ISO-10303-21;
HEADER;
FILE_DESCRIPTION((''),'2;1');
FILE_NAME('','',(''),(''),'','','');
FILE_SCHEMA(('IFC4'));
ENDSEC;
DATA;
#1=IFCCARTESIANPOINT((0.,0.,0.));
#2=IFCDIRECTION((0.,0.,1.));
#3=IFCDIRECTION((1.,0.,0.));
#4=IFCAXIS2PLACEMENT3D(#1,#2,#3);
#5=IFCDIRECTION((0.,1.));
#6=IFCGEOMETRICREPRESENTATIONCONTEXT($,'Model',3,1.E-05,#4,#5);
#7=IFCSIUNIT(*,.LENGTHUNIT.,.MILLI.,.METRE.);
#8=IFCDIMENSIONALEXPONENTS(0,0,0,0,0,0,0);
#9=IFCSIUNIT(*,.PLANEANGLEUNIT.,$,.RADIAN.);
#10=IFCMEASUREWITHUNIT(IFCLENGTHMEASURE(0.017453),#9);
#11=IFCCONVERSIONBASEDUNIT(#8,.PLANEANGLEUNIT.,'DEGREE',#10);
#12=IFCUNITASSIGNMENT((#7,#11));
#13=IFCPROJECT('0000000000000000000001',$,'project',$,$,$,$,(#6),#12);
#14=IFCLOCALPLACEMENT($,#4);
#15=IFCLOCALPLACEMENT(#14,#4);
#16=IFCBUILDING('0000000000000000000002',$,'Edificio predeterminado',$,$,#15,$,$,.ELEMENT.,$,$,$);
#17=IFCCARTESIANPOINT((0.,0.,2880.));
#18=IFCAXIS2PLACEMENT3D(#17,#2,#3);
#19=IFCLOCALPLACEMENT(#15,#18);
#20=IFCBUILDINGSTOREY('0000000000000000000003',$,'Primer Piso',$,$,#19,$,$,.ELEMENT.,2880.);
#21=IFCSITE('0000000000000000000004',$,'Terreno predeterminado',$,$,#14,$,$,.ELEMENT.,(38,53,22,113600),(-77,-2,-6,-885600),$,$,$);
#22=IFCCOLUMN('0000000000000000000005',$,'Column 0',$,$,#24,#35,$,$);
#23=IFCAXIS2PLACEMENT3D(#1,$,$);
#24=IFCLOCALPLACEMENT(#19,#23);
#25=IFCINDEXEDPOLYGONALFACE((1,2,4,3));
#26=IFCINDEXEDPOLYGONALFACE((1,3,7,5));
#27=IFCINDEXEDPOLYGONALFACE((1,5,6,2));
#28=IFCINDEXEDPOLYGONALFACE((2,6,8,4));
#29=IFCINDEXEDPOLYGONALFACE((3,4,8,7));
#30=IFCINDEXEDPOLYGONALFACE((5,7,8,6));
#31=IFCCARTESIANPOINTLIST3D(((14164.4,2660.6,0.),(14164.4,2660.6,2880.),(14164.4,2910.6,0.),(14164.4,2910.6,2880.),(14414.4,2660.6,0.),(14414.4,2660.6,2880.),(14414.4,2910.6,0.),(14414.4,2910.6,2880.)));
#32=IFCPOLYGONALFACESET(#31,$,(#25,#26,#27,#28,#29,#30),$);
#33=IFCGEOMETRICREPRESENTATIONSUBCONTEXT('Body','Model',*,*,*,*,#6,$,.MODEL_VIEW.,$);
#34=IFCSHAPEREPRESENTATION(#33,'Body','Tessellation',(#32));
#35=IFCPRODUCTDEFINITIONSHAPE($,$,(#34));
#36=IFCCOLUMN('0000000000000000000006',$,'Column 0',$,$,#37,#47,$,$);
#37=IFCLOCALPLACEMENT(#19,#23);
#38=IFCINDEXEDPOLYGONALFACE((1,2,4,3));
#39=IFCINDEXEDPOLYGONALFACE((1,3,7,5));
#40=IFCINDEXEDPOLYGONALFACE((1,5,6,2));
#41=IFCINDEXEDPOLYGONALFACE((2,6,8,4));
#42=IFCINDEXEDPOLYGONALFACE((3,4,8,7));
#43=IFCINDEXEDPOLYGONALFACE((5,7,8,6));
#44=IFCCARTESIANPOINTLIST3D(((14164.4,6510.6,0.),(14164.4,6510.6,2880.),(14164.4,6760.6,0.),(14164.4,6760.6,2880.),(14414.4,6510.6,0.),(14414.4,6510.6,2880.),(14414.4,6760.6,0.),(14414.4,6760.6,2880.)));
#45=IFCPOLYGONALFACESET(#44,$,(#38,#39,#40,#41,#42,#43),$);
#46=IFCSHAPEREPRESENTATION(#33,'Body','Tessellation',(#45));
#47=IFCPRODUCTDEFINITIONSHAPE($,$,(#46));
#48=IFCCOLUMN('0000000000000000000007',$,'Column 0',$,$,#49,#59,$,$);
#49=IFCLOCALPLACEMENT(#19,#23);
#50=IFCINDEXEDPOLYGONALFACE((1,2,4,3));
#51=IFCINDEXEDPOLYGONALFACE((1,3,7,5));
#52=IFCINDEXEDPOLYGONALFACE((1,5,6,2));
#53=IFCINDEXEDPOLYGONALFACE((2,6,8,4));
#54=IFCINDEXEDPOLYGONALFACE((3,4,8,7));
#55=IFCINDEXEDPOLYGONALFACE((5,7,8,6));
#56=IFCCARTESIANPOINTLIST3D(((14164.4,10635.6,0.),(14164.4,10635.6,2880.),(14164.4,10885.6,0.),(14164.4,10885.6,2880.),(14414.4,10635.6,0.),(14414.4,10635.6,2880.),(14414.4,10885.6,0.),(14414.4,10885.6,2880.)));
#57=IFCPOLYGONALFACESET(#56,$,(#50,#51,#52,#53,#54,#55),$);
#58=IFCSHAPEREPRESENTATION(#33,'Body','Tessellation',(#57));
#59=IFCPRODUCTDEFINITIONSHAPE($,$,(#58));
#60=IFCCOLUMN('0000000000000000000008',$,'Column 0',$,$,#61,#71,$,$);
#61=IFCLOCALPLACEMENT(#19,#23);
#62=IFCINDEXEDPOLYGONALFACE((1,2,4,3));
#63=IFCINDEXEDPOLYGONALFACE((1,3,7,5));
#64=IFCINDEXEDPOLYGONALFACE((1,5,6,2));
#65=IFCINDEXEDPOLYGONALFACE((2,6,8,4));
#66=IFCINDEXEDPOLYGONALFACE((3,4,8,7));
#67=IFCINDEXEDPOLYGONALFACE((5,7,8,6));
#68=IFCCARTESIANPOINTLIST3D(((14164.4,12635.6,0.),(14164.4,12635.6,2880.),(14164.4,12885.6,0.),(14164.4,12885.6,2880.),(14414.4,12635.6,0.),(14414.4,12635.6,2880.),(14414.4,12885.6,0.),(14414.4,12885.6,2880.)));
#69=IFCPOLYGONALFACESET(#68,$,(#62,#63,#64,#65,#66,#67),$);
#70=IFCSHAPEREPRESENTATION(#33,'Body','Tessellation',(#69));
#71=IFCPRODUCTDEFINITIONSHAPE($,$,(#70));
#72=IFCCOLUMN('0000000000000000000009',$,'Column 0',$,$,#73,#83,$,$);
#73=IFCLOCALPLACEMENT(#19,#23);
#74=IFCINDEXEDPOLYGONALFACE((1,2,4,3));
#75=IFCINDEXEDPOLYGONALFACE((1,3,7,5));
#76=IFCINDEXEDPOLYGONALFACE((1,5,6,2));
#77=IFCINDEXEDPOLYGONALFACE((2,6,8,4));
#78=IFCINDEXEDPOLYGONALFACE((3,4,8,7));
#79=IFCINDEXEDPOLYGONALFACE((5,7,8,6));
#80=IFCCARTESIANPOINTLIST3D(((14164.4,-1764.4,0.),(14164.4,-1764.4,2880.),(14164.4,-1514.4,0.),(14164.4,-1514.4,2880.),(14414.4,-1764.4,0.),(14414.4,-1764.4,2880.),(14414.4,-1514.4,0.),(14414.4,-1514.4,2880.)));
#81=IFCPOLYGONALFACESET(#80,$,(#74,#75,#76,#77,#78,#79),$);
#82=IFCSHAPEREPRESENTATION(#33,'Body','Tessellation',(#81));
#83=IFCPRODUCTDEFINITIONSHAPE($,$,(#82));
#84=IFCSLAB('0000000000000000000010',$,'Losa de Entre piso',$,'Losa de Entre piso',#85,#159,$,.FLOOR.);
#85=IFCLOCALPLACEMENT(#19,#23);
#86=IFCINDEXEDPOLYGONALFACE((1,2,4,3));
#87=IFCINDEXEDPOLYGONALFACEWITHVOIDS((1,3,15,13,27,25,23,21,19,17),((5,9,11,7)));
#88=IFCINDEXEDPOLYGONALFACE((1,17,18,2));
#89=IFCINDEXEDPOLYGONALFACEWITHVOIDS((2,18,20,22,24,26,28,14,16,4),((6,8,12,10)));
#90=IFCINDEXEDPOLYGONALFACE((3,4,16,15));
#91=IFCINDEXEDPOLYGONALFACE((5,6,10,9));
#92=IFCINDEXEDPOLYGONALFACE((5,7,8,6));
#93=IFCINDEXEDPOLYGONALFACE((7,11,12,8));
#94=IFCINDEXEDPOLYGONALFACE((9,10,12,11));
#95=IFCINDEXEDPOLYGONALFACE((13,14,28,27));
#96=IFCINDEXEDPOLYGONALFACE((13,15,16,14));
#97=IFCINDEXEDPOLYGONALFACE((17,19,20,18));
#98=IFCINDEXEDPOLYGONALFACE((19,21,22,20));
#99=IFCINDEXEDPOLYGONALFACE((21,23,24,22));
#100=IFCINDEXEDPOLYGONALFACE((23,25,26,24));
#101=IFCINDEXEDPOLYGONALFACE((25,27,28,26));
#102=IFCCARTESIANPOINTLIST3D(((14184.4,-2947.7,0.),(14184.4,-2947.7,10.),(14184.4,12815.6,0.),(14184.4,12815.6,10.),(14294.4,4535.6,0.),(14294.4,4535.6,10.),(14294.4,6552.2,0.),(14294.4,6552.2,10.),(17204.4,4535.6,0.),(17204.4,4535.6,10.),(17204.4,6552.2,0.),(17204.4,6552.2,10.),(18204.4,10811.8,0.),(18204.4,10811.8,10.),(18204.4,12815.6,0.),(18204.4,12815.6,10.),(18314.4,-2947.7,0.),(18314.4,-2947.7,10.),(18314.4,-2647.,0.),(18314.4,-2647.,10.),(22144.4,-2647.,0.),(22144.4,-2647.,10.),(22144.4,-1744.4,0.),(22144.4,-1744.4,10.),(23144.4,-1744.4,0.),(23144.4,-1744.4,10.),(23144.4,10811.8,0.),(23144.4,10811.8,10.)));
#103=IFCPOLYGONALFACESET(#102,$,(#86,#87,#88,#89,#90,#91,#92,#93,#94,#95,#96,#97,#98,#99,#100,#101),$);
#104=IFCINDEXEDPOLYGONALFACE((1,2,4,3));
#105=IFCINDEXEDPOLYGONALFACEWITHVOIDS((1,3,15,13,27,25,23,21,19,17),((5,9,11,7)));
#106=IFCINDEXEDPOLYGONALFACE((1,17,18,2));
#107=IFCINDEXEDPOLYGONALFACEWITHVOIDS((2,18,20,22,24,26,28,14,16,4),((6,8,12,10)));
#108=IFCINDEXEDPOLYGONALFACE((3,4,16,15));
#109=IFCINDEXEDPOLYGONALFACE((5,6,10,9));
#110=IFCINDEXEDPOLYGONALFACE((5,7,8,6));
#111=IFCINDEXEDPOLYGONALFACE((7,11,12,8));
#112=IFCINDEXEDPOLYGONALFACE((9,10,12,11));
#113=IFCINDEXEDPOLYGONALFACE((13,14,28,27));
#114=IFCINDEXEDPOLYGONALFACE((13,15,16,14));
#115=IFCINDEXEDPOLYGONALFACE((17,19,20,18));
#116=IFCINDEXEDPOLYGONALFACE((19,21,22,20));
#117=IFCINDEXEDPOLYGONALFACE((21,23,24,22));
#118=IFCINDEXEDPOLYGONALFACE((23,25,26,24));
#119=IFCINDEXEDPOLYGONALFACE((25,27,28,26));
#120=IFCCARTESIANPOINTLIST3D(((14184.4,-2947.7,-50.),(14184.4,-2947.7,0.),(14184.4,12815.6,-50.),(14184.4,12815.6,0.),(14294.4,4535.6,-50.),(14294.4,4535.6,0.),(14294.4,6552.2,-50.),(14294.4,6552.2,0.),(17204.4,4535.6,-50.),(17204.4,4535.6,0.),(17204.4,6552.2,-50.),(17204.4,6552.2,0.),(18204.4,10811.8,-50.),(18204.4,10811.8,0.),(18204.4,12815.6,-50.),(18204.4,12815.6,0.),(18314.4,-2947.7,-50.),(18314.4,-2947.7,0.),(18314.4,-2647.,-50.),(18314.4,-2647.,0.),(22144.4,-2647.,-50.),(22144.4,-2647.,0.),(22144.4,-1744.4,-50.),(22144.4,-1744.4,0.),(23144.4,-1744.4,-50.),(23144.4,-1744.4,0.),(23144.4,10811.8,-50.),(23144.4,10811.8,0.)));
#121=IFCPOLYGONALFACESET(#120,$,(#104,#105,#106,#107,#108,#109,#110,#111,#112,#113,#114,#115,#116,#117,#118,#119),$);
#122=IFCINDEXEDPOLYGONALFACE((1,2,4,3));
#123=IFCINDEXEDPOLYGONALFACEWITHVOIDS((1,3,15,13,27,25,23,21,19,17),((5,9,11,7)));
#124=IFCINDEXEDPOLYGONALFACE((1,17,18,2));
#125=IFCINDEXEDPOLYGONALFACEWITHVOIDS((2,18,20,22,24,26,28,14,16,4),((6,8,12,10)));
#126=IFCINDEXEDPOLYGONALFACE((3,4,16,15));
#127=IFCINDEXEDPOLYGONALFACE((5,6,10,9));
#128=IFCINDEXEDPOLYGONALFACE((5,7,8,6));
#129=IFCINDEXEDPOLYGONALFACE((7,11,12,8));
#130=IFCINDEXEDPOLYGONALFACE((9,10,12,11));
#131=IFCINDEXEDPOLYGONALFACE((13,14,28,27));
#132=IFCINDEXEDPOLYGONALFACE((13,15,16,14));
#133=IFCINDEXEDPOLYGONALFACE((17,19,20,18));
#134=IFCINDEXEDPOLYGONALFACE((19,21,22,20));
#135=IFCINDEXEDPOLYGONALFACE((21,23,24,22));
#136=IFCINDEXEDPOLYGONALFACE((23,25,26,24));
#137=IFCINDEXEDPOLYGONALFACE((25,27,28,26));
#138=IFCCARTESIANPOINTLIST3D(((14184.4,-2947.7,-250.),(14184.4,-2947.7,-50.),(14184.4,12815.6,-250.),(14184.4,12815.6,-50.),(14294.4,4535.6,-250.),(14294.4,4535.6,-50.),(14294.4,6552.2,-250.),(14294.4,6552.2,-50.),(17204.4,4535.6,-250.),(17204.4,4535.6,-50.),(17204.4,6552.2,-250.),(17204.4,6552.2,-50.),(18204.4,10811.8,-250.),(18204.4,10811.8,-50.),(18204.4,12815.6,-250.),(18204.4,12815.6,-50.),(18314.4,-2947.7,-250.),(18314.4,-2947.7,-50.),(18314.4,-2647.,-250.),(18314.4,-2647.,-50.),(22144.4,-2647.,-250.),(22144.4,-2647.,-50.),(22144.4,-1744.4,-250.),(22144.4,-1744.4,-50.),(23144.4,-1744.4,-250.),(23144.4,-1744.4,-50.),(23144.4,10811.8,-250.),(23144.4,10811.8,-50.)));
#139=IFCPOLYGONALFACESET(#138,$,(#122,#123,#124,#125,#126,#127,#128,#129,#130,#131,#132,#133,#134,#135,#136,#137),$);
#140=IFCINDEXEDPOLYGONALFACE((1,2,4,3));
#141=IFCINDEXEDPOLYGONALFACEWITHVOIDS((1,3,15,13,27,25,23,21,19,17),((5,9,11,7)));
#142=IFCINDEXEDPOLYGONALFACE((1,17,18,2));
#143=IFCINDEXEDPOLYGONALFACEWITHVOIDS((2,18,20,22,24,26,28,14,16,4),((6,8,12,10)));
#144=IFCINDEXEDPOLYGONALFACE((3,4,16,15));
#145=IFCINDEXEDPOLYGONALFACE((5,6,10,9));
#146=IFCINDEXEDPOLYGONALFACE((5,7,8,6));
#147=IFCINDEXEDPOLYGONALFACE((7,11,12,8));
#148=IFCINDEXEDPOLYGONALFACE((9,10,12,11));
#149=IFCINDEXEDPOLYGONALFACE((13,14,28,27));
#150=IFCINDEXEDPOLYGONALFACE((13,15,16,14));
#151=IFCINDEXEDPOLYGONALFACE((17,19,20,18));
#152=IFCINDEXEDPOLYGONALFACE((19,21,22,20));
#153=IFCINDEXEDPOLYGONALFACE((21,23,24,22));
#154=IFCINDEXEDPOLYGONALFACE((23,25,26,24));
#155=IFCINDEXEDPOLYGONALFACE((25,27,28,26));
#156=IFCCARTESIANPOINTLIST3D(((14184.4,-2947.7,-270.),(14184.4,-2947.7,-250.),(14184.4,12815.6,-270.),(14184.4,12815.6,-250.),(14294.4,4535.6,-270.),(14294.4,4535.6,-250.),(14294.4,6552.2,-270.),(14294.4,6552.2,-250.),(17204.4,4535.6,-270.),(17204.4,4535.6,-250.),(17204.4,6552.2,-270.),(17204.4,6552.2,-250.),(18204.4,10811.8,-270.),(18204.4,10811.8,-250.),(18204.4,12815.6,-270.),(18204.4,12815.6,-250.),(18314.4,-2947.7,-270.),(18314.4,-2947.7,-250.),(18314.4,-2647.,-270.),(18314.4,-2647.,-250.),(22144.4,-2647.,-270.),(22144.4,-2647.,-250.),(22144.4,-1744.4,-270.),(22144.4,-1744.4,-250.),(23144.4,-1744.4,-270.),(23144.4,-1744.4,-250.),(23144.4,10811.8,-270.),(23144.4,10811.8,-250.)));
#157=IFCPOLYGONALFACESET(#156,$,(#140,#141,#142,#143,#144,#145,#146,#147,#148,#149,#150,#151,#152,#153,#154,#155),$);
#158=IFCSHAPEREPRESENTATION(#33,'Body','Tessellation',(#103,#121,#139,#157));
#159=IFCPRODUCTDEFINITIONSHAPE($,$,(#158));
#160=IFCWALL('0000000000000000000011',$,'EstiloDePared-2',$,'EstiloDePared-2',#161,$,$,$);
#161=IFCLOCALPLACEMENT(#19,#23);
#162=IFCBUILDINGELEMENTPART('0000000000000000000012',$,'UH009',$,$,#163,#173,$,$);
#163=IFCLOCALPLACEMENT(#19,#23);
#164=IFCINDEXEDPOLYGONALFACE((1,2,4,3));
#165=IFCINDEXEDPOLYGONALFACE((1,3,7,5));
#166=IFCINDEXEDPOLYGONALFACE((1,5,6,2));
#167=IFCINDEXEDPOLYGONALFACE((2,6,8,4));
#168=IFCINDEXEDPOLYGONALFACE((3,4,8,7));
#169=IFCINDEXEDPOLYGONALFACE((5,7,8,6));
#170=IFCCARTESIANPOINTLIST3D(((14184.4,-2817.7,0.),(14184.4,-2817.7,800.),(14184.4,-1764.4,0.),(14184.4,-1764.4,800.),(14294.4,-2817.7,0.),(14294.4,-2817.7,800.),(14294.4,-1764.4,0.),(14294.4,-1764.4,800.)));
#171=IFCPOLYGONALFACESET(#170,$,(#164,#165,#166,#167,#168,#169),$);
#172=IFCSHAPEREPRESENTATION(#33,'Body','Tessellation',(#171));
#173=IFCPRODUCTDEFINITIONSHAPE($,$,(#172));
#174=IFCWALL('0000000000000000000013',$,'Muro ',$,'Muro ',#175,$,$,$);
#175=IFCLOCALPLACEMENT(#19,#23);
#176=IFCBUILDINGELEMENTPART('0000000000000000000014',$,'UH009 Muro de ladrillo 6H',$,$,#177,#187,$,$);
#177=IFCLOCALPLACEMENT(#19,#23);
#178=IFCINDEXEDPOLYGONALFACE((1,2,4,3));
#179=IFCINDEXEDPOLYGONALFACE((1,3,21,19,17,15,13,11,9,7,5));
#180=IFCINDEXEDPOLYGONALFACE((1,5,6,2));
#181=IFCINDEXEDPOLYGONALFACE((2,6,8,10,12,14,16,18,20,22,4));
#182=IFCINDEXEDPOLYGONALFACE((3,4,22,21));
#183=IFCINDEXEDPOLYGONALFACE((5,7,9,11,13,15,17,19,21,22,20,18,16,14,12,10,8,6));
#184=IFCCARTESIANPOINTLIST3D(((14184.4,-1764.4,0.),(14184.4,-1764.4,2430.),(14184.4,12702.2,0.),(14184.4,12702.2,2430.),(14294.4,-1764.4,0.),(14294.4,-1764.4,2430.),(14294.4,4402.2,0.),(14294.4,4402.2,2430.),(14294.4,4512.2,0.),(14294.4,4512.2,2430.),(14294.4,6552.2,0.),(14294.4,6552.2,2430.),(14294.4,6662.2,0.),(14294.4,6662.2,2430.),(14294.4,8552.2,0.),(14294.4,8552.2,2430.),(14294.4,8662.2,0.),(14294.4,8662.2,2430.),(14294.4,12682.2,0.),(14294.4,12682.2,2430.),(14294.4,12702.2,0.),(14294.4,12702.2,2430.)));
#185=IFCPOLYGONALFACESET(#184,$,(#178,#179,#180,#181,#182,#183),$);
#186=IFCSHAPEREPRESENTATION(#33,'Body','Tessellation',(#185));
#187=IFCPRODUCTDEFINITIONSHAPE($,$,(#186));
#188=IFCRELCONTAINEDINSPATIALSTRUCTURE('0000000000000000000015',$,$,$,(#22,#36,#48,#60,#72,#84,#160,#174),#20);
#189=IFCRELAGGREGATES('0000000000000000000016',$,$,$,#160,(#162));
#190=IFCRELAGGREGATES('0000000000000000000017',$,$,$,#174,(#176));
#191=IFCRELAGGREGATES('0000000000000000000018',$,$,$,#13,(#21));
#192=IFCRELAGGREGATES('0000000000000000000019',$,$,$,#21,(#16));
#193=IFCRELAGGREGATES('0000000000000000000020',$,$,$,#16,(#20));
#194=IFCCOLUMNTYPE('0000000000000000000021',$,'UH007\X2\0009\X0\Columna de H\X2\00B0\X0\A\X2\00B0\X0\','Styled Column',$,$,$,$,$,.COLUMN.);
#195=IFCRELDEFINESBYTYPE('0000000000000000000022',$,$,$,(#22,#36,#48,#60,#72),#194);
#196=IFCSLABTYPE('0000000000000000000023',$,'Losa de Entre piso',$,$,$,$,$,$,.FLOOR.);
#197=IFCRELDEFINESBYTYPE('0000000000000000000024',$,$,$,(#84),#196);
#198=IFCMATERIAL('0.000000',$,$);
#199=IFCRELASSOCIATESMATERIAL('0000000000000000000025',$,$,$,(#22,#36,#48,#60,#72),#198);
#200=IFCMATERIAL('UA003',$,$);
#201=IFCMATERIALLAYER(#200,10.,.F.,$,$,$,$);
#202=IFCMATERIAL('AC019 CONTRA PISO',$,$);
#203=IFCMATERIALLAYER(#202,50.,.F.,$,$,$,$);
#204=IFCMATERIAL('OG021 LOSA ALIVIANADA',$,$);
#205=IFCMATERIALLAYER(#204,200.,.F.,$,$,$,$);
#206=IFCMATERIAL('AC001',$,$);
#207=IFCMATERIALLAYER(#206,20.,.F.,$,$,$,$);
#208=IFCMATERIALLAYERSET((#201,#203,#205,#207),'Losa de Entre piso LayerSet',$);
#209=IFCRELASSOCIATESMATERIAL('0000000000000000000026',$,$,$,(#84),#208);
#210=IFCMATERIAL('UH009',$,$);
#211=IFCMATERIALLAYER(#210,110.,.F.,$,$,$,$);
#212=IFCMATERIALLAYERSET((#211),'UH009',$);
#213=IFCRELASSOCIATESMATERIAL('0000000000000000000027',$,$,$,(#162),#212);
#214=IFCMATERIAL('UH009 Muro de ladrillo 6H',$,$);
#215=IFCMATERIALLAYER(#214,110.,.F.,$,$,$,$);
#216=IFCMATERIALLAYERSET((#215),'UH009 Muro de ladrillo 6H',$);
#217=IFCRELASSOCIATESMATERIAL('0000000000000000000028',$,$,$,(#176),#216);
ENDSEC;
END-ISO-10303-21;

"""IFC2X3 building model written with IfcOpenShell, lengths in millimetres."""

from ifc_helpers import new_model, entity, si_unit, converted_unit, direction, frame, origin_with_axes, place, context, subcontext, project, spatial, polyline, outline, extrude, material, layer, layer_set, layer_usage, type_object, element, aggregate, save


model = new_model("IFC2X3")

# Units and contexts
model_context = context("Model", 3, precision=1e-05, world=origin_with_axes(), true_north=direction((0.0, 1.0)))
body_context = subcontext(model_context, "Body", "Model", "MODEL_VIEW")
ifc_project = project(units=[si_unit("LENGTHUNIT", "METRE", prefix="MILLI"), converted_unit("PLANEANGLEUNIT", "DEGREE", entity("IfcLengthMeasure", 0.017453), si_unit("PLANEANGLEUNIT", "RADIAN"), dimensions=[0, 0, 0, 0, 0, 0, 0])], contexts=[model_context])

# Site, building, storey
site_placement = place(None, origin_with_axes())
site = spatial("IfcSite", under=ifc_project, at=site_placement, Name="Terreno predeterminado", CompositionType="ELEMENT", RefLatitude=(38, 53, 22, 113600), RefLongitude=(-77, -2, -6, -885600))
building_placement = place(site_placement, origin_with_axes())
building = spatial("IfcBuilding", under=site, at=building_placement, Name="Edificio predeterminado", CompositionType="ELEMENT")
storey_placement = place(building_placement, frame((0.0, 0.0, 2880.0), z_axis=(0.0, 0.0, 1.0), x_axis=(1.0, 0.0, 0.0)))
storey = spatial("IfcBuildingStorey", under=building, at=storey_placement, Name="Primer Piso", CompositionType="ELEMENT", Elevation=2880.0)

# Columns
ifc_material_1 = material(Name="0.000000")
column_type = type_object("IfcColumnType", Name="UH007\tColumna de H°A°", Description="Styled Column", PredefinedType="COLUMN")
for number, where, z_axis, x_axis, name in (
    (1, (14289.4, 2785.6, 0.0), (0.0, 0.0, 1.0), (1.0, 0.0, 0.0), "Column 0"),
    (2, (14289.4, 6635.6, 0.0), (0.0, 0.0, 1.0), (1.0, 0.0, 0.0), "Column 0"),
    (3, (14289.4, 10760.6, 0.0), (0.0, 0.0, 1.0), (1.0, 0.0, 0.0), "Column 0"),
    (4, (14289.4, 12760.6, 0.0), (0.0, 0.0, 1.0), (1.0, 0.0, 0.0), "Column 0"),
    (5, (14289.4, -1639.4, 0.0), (0.0, 0.0, 1.0), (1.0, 0.0, 0.0), "Column 0"),
):
    element("IfcColumn", number, at=place(storey_placement, frame(where, z_axis=z_axis, x_axis=x_axis)), inside=storey, type_object=column_type, material=ifc_material_1, Name=name, context=body_context, shape_type="SweptSolid", body=[
        extrude(outline(polyline([(-125.0, -125.0), (125.0, -125.0), (125.0, 125.0), (-125.0, 125.0), (-125.0, -125.0)])), origin_with_axes(), (0.0, 0.0, 1.0), 2880.0),
    ])

# Slab
ifc_material_2 = material(Name="UA003")
ifc_layer_1 = layer(ifc_material_2, 10.0, ventilated=False)
ifc_material_3 = material(Name="AC019 CONTRA PISO")
ifc_layer_2 = layer(ifc_material_3, 50.0, ventilated=False)
ifc_material_4 = material(Name="OG021 LOSA ALIVIANADA")
ifc_layer_3 = layer(ifc_material_4, 200.0, ventilated=False)
ifc_material_5 = material(Name="AC001")
ifc_layer_4 = layer(ifc_material_5, 20.0, ventilated=False)
ifc_layer_set_1 = layer_set([ifc_layer_1, ifc_layer_2, ifc_layer_3, ifc_layer_4], Name="Losa de Entre piso LayerSet")
ifc_layer_usage_1 = layer_usage(ifc_layer_set_1, "AXIS3", "NEGATIVE", 0.0)
slab_type = type_object("IfcSlabType", Name="Losa de Entre piso", PredefinedType="FLOOR")
slab_placement = place(storey_placement, frame((0.0, 0.0, -2880.0), z_axis=(0.0, 0.0, 1.0), x_axis=(1.0, 0.0, 0.0)))
element("IfcSlab", 6, at=slab_placement, inside=storey, type_object=slab_type, material=ifc_layer_usage_1, Name="Losa de Entre piso", ObjectType="Losa de Entre piso", PredefinedType="FLOOR", context=body_context, shape_type="SweptSolid", body=[
    extrude(outline(polyline([(0.0, 15763.4), (4130.0, 15763.4), (4130.0, 15462.6), (7960.0, 15462.6), (7960.0, 14560.0), (8960.0, 14560.0), (8960.0, 2003.8), (4020.0, 2003.8), (4020.0, 0.0), (0.0, 0.0), (0.0, 15763.4)]), holes=[polyline([(110.0, 6263.4), (3020.0, 6263.4), (3020.0, 8280.0), (110.0, 8280.0), (110.0, 6263.4)])]), frame((14184.4, 12815.6, 2880.0), z_axis=(0.0, 0.0, -1.0), x_axis=(1.0, 0.0, 0.0)), (0.0, 0.0, -1.0), 10.0),
    extrude(outline(polyline([(0.0, 15763.4), (4130.0, 15763.4), (4130.0, 15462.6), (7960.0, 15462.6), (7960.0, 14560.0), (8960.0, 14560.0), (8960.0, 2003.8), (4020.0, 2003.8), (4020.0, 0.0), (0.0, 0.0), (0.0, 15763.4)]), holes=[polyline([(110.0, 6263.4), (3020.0, 6263.4), (3020.0, 8280.0), (110.0, 8280.0), (110.0, 6263.4)])]), frame((14184.4, 12815.6, 2830.0), z_axis=(0.0, 0.0, -1.0), x_axis=(1.0, 0.0, 0.0)), (0.0, 0.0, -1.0), 50.0),
    extrude(outline(polyline([(0.0, 15763.4), (4130.0, 15763.4), (4130.0, 15462.6), (7960.0, 15462.6), (7960.0, 14560.0), (8960.0, 14560.0), (8960.0, 2003.8), (4020.0, 2003.8), (4020.0, 0.0), (0.0, 0.0), (0.0, 15763.4)]), holes=[polyline([(110.0, 6263.4), (3020.0, 6263.4), (3020.0, 8280.0), (110.0, 8280.0), (110.0, 6263.4)])]), frame((14184.4, 12815.6, 2630.0), z_axis=(0.0, 0.0, -1.0), x_axis=(1.0, 0.0, 0.0)), (0.0, 0.0, -1.0), 200.0),
    extrude(outline(polyline([(0.0, 15763.4), (4130.0, 15763.4), (4130.0, 15462.6), (7960.0, 15462.6), (7960.0, 14560.0), (8960.0, 14560.0), (8960.0, 2003.8), (4020.0, 2003.8), (4020.0, 0.0), (0.0, 0.0), (0.0, 15763.4)]), holes=[polyline([(110.0, 6263.4), (3020.0, 6263.4), (3020.0, 8280.0), (110.0, 8280.0), (110.0, 6263.4)])]), frame((14184.4, 12815.6, 2610.0), z_axis=(0.0, 0.0, -1.0), x_axis=(1.0, 0.0, 0.0)), (0.0, 0.0, -1.0), 20.0),
])

# Walls, building element parts
wall_1_placement = place(storey_placement, frame((14239.4, -2817.7, 0.0), z_axis=(0.0, 0.0, 1.0), x_axis=(0.0, 1.0, 0.0)))
wall_1 = element("IfcWall", 7, at=wall_1_placement, inside=storey, Name="EstiloDePared-2", ObjectType="EstiloDePared-2")
ifc_material_6 = material(Name="UH009")
ifc_layer_5 = layer(ifc_material_6, 110.0, ventilated=False)
ifc_layer_set_2 = layer_set([ifc_layer_5], Name="UH009")
ifc_layer_usage_2 = layer_usage(ifc_layer_set_2, "AXIS2", "NEGATIVE", -55.0)
building_element_part_1_placement = place(wall_1_placement, origin_with_axes())
building_element_part_1 = element("IfcBuildingElementPart", 8, at=building_element_part_1_placement, material=ifc_layer_usage_2, Name="UH009", context=body_context, shape_type="SweptSolid", body=[
    extrude(outline(polyline([(1053.4, 55.0), (1053.4, -55.0), (0.0, -55.0), (0.0, 55.0), (1053.4, 55.0)])), origin_with_axes(), (0.0, 0.0, 1.0), 800.0),
])
aggregate(wall_1, [building_element_part_1])
wall_2_placement = place(storey_placement, frame((14239.4, -1764.4, 0.0), z_axis=(0.0, 0.0, 1.0), x_axis=(0.0, 1.0, 0.0)))
wall_2 = element("IfcWall", 9, at=wall_2_placement, inside=storey, Name="Muro ", ObjectType="Muro ")
ifc_material_7 = material(Name="UH009 Muro de ladrillo 6H")
ifc_layer_6 = layer(ifc_material_7, 110.0, ventilated=False)
ifc_layer_set_3 = layer_set([ifc_layer_6], Name="UH009 Muro de ladrillo 6H")
ifc_layer_usage_3 = layer_usage(ifc_layer_set_3, "AXIS2", "NEGATIVE", -55.0)
building_element_part_2_placement = place(wall_2_placement, origin_with_axes())
building_element_part_2 = element("IfcBuildingElementPart", 10, at=building_element_part_2_placement, material=ifc_layer_usage_3, Name="UH009 Muro de ladrillo 6H", context=body_context, shape_type="SweptSolid", body=[
    extrude(outline(polyline([(14466.6, 55.0), (14466.6, -55.0), (14446.6, -55.0), (10426.6, -55.0), (10316.6, -55.0), (8426.6, -55.0), (8316.6, -55.0), (6276.6, -55.0), (6166.6, -55.0), (0.0, -55.0), (0.0, 55.0), (14466.6, 55.0)])), origin_with_axes(), (0.0, 0.0, 1.0), 2430.0),
])
aggregate(wall_2, [building_element_part_2])

save(model, "model.ifc")
